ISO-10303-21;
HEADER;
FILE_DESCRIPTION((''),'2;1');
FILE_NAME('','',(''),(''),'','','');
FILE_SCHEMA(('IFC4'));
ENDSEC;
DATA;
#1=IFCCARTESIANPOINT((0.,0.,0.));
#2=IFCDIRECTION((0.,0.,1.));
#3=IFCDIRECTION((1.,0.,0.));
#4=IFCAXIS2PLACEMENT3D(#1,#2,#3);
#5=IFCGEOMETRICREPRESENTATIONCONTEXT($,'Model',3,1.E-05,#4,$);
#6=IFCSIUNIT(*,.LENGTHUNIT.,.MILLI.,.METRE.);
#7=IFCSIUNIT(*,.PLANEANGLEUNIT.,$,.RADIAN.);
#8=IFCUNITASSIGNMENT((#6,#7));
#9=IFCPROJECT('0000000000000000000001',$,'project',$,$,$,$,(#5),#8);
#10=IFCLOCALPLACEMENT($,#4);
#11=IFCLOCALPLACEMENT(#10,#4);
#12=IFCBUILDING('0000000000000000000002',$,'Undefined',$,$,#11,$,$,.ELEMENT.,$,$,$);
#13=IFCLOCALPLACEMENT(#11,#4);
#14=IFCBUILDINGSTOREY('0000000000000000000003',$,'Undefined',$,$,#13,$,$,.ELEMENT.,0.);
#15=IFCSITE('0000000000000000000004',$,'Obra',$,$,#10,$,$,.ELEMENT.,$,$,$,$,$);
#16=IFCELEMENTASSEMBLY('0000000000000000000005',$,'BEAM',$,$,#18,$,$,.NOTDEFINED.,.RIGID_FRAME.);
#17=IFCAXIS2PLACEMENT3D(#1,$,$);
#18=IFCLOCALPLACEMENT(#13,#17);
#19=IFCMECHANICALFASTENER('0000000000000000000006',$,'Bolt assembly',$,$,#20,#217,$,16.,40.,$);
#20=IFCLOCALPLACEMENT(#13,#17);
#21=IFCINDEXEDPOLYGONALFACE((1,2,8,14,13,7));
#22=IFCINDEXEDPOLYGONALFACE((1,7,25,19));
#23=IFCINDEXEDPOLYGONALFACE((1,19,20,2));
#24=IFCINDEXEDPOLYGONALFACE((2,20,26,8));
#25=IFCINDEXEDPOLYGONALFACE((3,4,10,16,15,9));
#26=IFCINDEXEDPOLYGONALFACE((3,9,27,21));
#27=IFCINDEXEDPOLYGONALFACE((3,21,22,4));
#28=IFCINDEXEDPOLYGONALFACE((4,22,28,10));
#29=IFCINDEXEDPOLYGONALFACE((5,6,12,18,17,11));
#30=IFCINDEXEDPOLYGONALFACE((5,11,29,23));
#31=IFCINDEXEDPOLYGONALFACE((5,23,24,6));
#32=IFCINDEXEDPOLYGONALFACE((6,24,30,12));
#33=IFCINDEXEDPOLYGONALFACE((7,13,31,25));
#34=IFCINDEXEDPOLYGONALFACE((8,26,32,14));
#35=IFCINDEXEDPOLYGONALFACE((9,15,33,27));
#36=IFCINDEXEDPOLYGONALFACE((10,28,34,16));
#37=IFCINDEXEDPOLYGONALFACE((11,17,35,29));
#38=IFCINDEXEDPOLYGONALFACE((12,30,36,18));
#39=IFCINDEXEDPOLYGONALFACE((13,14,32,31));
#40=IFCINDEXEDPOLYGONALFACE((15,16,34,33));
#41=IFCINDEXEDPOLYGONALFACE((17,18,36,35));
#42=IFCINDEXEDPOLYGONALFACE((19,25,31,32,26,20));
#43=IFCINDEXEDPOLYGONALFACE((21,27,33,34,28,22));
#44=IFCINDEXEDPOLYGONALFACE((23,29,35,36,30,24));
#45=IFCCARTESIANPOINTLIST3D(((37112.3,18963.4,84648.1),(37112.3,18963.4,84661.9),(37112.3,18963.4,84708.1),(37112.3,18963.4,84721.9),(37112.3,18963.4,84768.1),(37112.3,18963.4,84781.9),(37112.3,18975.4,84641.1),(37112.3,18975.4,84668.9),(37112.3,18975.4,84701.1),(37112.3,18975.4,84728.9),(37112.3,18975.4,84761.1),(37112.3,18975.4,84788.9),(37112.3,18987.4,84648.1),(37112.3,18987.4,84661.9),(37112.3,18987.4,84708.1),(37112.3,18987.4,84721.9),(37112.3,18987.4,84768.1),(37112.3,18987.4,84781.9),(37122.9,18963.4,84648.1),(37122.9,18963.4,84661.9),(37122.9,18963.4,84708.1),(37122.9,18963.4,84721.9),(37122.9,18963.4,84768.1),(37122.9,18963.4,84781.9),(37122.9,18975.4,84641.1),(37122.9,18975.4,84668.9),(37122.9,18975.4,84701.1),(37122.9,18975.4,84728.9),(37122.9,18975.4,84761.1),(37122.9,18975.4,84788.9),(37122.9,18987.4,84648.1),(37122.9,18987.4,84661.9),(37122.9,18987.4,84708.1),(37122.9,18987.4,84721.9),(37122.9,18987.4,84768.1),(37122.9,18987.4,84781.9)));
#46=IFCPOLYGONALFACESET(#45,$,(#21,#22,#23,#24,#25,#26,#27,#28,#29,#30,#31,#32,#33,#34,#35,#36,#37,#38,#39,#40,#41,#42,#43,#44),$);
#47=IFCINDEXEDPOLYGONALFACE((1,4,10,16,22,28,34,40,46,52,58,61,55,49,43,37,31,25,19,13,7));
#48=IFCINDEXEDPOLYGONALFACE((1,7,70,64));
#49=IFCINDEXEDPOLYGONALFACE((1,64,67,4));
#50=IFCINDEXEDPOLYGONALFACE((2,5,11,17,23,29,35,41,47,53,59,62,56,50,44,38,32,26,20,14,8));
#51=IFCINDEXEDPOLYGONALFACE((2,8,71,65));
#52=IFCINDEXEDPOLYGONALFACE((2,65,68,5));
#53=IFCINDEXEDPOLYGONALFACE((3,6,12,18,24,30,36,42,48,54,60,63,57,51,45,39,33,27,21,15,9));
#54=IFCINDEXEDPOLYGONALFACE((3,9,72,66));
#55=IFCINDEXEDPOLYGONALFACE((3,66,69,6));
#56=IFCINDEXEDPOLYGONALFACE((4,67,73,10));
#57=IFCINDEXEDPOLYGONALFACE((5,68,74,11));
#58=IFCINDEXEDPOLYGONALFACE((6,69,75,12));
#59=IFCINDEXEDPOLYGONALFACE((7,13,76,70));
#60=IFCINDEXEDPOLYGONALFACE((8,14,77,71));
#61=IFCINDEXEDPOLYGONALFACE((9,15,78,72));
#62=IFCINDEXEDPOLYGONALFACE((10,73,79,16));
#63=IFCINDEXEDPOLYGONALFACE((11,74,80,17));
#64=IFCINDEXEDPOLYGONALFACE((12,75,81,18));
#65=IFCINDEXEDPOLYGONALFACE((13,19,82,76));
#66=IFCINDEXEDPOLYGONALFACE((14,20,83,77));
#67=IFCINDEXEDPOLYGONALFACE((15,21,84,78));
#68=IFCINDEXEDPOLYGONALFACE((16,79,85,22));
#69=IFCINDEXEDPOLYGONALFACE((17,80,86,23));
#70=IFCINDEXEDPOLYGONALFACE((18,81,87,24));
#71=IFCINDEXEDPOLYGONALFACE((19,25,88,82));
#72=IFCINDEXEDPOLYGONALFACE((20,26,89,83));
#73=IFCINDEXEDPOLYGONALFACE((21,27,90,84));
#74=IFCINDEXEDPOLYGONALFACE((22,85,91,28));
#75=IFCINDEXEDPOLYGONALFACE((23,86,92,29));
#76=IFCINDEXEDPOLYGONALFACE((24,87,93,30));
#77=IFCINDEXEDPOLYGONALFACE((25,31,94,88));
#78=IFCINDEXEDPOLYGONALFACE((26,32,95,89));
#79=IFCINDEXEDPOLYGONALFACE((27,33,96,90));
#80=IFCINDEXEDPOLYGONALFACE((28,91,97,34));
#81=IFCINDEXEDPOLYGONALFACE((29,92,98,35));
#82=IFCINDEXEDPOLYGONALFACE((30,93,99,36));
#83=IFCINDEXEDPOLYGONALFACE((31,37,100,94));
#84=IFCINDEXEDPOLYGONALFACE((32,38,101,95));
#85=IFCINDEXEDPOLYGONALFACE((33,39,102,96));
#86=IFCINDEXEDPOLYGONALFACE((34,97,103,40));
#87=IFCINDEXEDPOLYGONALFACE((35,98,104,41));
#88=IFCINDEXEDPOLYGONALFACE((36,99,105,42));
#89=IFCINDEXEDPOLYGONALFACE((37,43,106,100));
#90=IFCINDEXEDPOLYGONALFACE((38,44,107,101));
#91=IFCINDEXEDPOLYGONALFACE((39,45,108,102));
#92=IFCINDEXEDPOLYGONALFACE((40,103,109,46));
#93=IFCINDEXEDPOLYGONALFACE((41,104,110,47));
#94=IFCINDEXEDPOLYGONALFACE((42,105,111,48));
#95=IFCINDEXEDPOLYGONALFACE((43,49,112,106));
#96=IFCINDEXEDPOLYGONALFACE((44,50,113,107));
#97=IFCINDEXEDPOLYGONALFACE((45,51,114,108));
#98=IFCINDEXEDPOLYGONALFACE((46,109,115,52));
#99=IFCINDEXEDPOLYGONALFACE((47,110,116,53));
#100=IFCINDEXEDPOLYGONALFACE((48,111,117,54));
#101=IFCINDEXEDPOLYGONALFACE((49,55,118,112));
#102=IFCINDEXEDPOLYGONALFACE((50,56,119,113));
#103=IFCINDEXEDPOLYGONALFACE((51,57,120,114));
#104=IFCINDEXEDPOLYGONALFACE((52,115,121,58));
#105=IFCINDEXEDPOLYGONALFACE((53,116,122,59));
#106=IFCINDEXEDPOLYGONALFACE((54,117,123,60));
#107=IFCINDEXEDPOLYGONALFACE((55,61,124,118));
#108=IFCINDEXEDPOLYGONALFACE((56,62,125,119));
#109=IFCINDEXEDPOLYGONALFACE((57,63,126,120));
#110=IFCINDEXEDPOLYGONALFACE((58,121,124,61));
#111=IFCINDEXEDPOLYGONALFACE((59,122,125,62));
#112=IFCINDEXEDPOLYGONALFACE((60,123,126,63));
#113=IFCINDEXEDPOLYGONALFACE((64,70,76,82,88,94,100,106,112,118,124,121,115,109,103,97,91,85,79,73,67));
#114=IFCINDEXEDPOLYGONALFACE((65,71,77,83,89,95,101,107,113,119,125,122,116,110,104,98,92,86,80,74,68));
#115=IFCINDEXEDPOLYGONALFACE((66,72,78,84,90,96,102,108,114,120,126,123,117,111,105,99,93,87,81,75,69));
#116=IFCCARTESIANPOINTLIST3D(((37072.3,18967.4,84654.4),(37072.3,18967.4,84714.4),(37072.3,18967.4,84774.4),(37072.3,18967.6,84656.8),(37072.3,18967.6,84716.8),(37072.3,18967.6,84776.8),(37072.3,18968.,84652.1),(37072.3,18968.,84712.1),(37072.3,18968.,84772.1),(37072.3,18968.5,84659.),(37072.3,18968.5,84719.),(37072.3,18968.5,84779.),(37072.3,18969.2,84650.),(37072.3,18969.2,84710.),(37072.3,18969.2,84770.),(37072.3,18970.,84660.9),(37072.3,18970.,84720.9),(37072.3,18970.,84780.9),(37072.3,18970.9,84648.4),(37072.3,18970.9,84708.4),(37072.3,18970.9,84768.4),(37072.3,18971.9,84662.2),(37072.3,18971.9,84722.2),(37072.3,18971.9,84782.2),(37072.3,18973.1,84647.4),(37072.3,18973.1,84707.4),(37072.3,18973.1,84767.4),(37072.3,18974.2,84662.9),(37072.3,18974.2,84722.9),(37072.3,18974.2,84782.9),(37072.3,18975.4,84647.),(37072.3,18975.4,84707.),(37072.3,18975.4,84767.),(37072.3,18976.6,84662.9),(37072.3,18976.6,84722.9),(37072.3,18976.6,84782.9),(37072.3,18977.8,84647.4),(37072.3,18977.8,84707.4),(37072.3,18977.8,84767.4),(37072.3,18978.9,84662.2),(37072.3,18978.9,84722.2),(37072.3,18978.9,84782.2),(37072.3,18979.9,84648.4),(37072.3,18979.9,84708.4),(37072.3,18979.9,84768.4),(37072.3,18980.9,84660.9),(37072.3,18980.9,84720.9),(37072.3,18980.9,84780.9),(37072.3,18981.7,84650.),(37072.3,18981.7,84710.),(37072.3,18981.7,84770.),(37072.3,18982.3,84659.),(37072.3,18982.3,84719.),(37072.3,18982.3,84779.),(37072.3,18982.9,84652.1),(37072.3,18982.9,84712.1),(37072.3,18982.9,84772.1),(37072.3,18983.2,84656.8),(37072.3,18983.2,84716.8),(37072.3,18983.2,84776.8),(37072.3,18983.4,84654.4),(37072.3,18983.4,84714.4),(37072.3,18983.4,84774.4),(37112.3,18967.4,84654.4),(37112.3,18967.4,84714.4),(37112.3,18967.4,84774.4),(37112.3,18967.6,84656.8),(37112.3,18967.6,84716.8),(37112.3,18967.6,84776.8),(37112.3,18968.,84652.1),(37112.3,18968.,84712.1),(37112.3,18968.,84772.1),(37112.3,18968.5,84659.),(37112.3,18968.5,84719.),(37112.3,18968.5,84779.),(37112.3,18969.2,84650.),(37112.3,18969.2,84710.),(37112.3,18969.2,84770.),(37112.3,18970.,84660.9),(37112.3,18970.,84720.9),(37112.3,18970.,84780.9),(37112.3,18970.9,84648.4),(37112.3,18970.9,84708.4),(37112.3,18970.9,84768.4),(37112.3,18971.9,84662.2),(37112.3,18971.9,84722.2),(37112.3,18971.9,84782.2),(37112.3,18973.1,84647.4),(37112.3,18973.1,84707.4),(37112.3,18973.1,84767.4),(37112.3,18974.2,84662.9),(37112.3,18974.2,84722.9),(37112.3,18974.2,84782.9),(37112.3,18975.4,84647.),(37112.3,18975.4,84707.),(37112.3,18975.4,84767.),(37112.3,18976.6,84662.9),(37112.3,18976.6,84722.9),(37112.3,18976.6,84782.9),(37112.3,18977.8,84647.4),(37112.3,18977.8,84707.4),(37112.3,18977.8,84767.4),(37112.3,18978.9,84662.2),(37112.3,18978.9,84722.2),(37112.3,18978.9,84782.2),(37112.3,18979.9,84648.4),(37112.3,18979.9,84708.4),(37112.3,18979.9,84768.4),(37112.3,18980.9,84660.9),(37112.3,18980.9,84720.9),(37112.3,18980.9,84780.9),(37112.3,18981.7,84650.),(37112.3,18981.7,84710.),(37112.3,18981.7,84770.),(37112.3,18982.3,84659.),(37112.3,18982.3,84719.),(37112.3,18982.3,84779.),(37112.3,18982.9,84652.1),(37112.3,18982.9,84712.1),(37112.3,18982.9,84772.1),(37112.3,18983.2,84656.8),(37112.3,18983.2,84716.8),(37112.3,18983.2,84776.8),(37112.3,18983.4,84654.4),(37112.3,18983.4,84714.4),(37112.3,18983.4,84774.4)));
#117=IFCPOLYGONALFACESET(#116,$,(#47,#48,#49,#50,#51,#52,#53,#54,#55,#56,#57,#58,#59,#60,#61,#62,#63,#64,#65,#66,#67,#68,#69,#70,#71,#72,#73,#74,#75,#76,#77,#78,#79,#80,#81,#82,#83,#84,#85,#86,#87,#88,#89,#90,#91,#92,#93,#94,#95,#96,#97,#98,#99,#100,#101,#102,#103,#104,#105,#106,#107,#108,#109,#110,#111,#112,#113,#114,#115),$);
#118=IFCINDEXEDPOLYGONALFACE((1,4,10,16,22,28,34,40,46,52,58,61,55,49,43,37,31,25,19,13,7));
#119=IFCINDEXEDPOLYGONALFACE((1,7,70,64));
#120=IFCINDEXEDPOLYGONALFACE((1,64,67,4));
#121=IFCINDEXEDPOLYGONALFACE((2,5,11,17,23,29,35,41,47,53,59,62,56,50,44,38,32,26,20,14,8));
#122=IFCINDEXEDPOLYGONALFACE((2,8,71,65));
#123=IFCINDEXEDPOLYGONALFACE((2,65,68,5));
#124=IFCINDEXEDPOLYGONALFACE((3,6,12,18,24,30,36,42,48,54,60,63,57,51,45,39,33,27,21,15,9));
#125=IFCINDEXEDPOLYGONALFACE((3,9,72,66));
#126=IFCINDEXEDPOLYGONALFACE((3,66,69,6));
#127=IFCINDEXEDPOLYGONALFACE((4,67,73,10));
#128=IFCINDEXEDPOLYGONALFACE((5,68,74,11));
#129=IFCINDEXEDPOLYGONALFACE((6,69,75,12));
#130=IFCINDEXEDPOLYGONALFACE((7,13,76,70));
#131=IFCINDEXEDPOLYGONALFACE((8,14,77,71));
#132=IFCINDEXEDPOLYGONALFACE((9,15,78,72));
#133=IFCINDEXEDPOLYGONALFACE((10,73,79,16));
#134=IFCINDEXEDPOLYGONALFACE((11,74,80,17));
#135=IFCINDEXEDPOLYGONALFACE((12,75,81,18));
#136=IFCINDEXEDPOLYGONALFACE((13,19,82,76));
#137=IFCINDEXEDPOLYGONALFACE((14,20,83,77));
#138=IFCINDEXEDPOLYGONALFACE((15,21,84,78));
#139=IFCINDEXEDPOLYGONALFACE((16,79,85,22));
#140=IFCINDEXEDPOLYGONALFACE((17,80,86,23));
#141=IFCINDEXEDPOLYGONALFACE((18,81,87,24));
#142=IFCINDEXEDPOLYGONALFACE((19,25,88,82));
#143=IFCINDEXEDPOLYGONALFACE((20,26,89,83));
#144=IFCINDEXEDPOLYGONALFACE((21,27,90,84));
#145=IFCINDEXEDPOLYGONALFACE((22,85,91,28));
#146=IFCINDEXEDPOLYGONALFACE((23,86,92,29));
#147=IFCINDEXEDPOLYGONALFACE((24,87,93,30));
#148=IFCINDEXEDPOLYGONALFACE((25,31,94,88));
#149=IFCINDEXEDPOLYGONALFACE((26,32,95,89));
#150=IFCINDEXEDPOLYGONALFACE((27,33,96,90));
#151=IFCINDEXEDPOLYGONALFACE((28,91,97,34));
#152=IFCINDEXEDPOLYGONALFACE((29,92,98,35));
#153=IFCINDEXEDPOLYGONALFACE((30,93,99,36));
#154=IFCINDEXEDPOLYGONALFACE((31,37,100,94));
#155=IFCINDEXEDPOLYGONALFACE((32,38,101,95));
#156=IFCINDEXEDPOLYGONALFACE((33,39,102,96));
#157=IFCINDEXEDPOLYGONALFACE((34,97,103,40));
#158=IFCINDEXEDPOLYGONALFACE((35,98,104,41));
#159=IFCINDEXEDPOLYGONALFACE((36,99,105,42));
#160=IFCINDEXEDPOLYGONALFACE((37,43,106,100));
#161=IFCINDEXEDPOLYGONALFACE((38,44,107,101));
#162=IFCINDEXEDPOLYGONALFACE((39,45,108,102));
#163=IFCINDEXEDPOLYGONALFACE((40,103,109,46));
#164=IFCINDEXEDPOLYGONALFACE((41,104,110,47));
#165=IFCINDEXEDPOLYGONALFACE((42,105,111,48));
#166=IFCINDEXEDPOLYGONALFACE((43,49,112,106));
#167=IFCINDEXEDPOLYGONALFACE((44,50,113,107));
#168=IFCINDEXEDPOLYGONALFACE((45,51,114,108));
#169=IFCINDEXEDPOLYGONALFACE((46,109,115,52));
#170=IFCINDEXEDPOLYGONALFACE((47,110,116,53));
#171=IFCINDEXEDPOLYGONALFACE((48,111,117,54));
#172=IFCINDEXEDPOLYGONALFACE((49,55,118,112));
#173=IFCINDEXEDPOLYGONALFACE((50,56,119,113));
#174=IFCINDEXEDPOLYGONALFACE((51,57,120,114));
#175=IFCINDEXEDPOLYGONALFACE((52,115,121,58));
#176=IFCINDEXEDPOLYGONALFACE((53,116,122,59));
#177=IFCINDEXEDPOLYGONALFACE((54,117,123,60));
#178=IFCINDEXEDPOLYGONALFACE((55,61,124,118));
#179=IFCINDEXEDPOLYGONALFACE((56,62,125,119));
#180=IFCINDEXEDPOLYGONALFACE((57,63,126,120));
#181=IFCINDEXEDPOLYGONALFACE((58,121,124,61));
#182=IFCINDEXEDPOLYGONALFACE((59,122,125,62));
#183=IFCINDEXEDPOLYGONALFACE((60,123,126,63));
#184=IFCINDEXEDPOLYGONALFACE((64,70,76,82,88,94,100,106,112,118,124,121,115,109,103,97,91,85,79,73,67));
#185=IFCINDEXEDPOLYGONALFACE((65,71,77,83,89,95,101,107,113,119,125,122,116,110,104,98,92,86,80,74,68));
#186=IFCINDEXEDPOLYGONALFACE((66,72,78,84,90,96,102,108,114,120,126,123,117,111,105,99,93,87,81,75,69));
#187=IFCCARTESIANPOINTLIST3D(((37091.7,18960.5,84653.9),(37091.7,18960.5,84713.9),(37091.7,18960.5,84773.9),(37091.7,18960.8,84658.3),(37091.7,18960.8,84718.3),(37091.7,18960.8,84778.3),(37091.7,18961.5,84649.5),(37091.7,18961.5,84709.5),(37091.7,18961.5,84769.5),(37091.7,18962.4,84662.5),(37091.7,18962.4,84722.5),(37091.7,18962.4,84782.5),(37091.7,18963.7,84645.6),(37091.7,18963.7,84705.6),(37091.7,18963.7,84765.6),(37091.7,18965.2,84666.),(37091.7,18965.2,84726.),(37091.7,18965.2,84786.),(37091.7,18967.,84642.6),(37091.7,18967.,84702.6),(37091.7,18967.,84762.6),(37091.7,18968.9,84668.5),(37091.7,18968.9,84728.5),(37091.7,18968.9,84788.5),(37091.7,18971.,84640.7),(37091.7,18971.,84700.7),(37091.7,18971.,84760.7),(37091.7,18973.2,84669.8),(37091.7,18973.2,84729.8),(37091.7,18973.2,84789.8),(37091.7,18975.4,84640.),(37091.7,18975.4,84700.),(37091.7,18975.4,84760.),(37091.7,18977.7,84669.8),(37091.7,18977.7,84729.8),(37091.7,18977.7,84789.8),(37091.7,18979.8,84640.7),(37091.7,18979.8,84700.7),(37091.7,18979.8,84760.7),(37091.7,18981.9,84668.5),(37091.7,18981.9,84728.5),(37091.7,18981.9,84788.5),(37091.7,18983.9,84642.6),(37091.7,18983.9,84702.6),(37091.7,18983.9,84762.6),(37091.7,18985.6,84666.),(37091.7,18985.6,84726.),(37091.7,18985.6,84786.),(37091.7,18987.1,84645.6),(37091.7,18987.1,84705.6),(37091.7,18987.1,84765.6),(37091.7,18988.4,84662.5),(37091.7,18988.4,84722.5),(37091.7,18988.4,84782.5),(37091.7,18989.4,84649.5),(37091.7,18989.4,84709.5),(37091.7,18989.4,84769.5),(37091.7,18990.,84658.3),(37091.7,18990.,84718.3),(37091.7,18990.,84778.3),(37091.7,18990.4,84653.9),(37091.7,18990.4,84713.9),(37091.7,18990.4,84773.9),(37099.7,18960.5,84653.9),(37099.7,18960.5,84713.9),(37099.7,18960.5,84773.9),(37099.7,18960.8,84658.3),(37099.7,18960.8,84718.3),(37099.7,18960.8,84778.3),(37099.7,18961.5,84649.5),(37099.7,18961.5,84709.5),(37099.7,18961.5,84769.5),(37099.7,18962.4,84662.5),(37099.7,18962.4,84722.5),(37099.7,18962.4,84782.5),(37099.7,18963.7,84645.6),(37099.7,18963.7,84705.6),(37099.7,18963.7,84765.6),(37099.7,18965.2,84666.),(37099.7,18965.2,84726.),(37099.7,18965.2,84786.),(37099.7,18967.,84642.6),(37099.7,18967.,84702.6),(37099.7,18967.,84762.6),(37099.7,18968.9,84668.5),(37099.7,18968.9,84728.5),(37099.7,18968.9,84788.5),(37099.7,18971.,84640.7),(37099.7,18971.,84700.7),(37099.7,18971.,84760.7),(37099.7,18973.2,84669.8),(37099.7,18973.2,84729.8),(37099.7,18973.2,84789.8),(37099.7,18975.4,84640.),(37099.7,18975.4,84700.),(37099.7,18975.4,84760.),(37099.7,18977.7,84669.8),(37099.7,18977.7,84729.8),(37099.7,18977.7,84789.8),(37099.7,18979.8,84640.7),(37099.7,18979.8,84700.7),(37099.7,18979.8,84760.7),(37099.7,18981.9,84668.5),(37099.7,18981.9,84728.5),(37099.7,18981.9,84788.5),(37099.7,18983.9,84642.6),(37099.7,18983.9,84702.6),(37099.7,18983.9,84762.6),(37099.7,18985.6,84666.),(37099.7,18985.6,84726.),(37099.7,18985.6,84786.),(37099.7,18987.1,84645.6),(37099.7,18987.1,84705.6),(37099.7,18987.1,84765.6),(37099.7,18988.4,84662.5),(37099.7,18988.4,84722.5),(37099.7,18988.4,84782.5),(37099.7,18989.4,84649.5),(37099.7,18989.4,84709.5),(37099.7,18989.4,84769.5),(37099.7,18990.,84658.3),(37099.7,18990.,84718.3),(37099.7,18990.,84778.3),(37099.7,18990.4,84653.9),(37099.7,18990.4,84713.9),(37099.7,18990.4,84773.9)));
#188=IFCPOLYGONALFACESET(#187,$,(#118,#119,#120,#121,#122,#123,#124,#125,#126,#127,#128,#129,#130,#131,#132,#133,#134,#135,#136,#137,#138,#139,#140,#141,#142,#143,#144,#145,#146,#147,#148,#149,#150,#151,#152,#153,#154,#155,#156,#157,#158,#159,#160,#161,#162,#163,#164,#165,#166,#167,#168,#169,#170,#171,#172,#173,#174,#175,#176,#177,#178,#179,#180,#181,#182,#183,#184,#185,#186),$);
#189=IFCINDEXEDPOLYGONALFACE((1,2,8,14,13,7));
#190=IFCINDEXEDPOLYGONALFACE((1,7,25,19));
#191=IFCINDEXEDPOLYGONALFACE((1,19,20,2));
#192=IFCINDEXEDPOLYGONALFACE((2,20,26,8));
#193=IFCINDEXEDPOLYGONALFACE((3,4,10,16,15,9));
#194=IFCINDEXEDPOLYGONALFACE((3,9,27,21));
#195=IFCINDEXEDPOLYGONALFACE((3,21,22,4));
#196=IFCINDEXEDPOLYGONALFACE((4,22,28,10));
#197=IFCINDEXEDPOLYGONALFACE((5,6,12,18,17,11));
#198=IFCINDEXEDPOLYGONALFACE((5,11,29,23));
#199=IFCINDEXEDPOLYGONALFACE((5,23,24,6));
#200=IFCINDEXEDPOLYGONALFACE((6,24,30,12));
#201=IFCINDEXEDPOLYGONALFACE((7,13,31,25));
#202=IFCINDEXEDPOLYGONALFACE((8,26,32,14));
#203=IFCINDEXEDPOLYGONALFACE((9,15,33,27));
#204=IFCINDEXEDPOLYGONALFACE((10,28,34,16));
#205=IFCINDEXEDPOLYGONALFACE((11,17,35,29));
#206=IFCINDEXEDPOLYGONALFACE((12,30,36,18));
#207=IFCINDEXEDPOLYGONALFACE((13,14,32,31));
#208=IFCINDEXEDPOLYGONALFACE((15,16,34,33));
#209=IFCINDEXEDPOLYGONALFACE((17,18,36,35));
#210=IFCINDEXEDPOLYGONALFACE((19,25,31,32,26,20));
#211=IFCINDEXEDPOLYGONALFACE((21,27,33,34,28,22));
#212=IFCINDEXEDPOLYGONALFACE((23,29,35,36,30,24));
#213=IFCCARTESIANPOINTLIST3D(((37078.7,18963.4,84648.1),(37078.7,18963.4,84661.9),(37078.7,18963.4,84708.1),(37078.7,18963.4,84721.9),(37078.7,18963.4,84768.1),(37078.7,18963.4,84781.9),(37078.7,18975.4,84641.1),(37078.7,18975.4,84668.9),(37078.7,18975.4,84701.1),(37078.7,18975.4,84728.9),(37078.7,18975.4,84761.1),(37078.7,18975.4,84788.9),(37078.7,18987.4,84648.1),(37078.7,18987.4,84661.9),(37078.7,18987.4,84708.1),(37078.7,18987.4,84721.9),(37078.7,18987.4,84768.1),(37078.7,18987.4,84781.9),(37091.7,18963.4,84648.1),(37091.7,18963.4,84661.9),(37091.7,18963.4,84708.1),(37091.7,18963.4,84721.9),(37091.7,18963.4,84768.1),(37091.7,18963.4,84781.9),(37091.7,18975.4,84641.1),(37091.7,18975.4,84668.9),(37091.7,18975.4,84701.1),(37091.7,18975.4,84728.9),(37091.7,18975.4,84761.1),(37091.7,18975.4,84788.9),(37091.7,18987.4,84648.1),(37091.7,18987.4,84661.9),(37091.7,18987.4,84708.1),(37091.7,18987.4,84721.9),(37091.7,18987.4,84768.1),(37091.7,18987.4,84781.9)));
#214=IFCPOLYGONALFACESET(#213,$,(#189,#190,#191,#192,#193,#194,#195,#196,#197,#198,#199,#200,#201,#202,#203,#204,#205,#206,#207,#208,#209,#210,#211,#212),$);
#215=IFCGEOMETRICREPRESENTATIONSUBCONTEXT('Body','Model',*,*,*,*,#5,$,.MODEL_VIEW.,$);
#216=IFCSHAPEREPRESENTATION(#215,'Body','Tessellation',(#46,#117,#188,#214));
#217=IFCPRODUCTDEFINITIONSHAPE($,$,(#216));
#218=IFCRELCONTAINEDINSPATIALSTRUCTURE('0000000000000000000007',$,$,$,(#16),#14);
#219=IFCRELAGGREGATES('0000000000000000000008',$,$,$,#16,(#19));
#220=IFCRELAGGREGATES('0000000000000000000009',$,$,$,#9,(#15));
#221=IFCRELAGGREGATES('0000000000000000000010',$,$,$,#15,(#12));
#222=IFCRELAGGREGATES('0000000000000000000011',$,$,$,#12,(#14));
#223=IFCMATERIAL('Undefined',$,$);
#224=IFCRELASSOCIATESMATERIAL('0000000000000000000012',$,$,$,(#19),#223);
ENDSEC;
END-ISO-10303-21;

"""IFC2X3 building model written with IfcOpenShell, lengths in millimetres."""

from ifc_helpers import new_model, si_unit, frame, origin_with_axes, origin_2d_with_axis, place, context, subcontext, project, spatial, polyline, circle, outline, extrude, source, transform, mapped, material, element, aggregate, save


model = new_model("IFC2X3")

# Units and contexts
model_context = context("Model", 3, precision=1e-05, world=origin_with_axes())
body_context = subcontext(model_context, "Body", "Model", "MODEL_VIEW")
ifc_project = project(units=[si_unit("LENGTHUNIT", "METRE", prefix="MILLI"), si_unit("PLANEANGLEUNIT", "RADIAN")], contexts=[model_context])

# Site, building, storey
site_placement = place(None, origin_with_axes())
site = spatial("IfcSite", under=ifc_project, at=site_placement, Name="Obra", CompositionType="ELEMENT")
building_placement = place(site_placement, origin_with_axes())
building = spatial("IfcBuilding", under=site, at=building_placement, Name="Undefined", CompositionType="ELEMENT")
storey_placement = place(building_placement, origin_with_axes())
storey = spatial("IfcBuildingStorey", under=building, at=storey_placement, Name="Undefined", CompositionType="ELEMENT", Elevation=0.0)

# Shared definitions
ifc_material_1 = material(Name="Undefined")
shared_shape_1 = source(origin_with_axes(), body_context, "Body", "SweptSolid", [
    extrude(outline(polyline([(13.9, 0.0), (6.9, 12.0), (-6.9, 12.0), (-13.9, 0.0), (-6.9, -12.0), (6.9, -12.0), (13.9, 0.0)])), frame((0.0, -19.9, 0.0), z_axis=(0.0, 1.0, 0.0), x_axis=(1.0, 0.0, 0.0)), (0.0, 0.0, 1.0), 10.6),
    extrude(circle(Radius=8.0, at=origin_2d_with_axis()), frame((0.0, -9.3, 0.0), z_axis=(0.0, 1.0, 0.0), x_axis=(1.0, 0.0, 0.0)), (0.0, 0.0, 1.0), 40.0),
    extrude(circle(Radius=15.0, at=origin_2d_with_axis()), frame((0.0, 3.3, 0.0), z_axis=(0.0, 1.0, 0.0), x_axis=(1.0, 0.0, 0.0)), (0.0, 0.0, 1.0), 8.0),
    extrude(outline(polyline([(13.9, 0.0), (6.9, 12.0), (-6.9, 12.0), (-13.9, 0.0), (-6.9, -12.0), (6.9, -12.0), (13.9, 0.0)])), frame((0.0, 11.3, 0.0), z_axis=(0.0, 1.0, 0.0), x_axis=(1.0, 0.0, 0.0)), (0.0, 0.0, 1.0), 13.0),
])

# Element assembly, mechanical fastener
assembly_1_placement = place(storey_placement, origin_with_axes())
assembly_1 = element("IfcElementAssembly", 1, at=assembly_1_placement, inside=storey, Name="BEAM", AssemblyPlace="NOTDEFINED", PredefinedType="RIGID_FRAME")
mechanical_fastener_1_placement = place(assembly_1_placement, frame((37103.0, 18925.4, 84850.0), z_axis=(0.0, 1.0, 0.0), x_axis=(0.0, 0.0, -1.0)))
mechanical_fastener_1 = element("IfcMechanicalFastener", 2, at=mechanical_fastener_1_placement, material=ifc_material_1, Name="Bolt assembly", NominalDiameter=16.0, NominalLength=40.0, context=body_context, shape_type="MappedRepresentation", body=[
    mapped(shared_shape_1, transform((75.0, 0.0, 50.0))),
    mapped(shared_shape_1, transform((135.0, 0.0, 50.0))),
    mapped(shared_shape_1, transform((195.0, 0.0, 50.0))),
])
aggregate(assembly_1, [mechanical_fastener_1])

save(model, "model.ifc")
